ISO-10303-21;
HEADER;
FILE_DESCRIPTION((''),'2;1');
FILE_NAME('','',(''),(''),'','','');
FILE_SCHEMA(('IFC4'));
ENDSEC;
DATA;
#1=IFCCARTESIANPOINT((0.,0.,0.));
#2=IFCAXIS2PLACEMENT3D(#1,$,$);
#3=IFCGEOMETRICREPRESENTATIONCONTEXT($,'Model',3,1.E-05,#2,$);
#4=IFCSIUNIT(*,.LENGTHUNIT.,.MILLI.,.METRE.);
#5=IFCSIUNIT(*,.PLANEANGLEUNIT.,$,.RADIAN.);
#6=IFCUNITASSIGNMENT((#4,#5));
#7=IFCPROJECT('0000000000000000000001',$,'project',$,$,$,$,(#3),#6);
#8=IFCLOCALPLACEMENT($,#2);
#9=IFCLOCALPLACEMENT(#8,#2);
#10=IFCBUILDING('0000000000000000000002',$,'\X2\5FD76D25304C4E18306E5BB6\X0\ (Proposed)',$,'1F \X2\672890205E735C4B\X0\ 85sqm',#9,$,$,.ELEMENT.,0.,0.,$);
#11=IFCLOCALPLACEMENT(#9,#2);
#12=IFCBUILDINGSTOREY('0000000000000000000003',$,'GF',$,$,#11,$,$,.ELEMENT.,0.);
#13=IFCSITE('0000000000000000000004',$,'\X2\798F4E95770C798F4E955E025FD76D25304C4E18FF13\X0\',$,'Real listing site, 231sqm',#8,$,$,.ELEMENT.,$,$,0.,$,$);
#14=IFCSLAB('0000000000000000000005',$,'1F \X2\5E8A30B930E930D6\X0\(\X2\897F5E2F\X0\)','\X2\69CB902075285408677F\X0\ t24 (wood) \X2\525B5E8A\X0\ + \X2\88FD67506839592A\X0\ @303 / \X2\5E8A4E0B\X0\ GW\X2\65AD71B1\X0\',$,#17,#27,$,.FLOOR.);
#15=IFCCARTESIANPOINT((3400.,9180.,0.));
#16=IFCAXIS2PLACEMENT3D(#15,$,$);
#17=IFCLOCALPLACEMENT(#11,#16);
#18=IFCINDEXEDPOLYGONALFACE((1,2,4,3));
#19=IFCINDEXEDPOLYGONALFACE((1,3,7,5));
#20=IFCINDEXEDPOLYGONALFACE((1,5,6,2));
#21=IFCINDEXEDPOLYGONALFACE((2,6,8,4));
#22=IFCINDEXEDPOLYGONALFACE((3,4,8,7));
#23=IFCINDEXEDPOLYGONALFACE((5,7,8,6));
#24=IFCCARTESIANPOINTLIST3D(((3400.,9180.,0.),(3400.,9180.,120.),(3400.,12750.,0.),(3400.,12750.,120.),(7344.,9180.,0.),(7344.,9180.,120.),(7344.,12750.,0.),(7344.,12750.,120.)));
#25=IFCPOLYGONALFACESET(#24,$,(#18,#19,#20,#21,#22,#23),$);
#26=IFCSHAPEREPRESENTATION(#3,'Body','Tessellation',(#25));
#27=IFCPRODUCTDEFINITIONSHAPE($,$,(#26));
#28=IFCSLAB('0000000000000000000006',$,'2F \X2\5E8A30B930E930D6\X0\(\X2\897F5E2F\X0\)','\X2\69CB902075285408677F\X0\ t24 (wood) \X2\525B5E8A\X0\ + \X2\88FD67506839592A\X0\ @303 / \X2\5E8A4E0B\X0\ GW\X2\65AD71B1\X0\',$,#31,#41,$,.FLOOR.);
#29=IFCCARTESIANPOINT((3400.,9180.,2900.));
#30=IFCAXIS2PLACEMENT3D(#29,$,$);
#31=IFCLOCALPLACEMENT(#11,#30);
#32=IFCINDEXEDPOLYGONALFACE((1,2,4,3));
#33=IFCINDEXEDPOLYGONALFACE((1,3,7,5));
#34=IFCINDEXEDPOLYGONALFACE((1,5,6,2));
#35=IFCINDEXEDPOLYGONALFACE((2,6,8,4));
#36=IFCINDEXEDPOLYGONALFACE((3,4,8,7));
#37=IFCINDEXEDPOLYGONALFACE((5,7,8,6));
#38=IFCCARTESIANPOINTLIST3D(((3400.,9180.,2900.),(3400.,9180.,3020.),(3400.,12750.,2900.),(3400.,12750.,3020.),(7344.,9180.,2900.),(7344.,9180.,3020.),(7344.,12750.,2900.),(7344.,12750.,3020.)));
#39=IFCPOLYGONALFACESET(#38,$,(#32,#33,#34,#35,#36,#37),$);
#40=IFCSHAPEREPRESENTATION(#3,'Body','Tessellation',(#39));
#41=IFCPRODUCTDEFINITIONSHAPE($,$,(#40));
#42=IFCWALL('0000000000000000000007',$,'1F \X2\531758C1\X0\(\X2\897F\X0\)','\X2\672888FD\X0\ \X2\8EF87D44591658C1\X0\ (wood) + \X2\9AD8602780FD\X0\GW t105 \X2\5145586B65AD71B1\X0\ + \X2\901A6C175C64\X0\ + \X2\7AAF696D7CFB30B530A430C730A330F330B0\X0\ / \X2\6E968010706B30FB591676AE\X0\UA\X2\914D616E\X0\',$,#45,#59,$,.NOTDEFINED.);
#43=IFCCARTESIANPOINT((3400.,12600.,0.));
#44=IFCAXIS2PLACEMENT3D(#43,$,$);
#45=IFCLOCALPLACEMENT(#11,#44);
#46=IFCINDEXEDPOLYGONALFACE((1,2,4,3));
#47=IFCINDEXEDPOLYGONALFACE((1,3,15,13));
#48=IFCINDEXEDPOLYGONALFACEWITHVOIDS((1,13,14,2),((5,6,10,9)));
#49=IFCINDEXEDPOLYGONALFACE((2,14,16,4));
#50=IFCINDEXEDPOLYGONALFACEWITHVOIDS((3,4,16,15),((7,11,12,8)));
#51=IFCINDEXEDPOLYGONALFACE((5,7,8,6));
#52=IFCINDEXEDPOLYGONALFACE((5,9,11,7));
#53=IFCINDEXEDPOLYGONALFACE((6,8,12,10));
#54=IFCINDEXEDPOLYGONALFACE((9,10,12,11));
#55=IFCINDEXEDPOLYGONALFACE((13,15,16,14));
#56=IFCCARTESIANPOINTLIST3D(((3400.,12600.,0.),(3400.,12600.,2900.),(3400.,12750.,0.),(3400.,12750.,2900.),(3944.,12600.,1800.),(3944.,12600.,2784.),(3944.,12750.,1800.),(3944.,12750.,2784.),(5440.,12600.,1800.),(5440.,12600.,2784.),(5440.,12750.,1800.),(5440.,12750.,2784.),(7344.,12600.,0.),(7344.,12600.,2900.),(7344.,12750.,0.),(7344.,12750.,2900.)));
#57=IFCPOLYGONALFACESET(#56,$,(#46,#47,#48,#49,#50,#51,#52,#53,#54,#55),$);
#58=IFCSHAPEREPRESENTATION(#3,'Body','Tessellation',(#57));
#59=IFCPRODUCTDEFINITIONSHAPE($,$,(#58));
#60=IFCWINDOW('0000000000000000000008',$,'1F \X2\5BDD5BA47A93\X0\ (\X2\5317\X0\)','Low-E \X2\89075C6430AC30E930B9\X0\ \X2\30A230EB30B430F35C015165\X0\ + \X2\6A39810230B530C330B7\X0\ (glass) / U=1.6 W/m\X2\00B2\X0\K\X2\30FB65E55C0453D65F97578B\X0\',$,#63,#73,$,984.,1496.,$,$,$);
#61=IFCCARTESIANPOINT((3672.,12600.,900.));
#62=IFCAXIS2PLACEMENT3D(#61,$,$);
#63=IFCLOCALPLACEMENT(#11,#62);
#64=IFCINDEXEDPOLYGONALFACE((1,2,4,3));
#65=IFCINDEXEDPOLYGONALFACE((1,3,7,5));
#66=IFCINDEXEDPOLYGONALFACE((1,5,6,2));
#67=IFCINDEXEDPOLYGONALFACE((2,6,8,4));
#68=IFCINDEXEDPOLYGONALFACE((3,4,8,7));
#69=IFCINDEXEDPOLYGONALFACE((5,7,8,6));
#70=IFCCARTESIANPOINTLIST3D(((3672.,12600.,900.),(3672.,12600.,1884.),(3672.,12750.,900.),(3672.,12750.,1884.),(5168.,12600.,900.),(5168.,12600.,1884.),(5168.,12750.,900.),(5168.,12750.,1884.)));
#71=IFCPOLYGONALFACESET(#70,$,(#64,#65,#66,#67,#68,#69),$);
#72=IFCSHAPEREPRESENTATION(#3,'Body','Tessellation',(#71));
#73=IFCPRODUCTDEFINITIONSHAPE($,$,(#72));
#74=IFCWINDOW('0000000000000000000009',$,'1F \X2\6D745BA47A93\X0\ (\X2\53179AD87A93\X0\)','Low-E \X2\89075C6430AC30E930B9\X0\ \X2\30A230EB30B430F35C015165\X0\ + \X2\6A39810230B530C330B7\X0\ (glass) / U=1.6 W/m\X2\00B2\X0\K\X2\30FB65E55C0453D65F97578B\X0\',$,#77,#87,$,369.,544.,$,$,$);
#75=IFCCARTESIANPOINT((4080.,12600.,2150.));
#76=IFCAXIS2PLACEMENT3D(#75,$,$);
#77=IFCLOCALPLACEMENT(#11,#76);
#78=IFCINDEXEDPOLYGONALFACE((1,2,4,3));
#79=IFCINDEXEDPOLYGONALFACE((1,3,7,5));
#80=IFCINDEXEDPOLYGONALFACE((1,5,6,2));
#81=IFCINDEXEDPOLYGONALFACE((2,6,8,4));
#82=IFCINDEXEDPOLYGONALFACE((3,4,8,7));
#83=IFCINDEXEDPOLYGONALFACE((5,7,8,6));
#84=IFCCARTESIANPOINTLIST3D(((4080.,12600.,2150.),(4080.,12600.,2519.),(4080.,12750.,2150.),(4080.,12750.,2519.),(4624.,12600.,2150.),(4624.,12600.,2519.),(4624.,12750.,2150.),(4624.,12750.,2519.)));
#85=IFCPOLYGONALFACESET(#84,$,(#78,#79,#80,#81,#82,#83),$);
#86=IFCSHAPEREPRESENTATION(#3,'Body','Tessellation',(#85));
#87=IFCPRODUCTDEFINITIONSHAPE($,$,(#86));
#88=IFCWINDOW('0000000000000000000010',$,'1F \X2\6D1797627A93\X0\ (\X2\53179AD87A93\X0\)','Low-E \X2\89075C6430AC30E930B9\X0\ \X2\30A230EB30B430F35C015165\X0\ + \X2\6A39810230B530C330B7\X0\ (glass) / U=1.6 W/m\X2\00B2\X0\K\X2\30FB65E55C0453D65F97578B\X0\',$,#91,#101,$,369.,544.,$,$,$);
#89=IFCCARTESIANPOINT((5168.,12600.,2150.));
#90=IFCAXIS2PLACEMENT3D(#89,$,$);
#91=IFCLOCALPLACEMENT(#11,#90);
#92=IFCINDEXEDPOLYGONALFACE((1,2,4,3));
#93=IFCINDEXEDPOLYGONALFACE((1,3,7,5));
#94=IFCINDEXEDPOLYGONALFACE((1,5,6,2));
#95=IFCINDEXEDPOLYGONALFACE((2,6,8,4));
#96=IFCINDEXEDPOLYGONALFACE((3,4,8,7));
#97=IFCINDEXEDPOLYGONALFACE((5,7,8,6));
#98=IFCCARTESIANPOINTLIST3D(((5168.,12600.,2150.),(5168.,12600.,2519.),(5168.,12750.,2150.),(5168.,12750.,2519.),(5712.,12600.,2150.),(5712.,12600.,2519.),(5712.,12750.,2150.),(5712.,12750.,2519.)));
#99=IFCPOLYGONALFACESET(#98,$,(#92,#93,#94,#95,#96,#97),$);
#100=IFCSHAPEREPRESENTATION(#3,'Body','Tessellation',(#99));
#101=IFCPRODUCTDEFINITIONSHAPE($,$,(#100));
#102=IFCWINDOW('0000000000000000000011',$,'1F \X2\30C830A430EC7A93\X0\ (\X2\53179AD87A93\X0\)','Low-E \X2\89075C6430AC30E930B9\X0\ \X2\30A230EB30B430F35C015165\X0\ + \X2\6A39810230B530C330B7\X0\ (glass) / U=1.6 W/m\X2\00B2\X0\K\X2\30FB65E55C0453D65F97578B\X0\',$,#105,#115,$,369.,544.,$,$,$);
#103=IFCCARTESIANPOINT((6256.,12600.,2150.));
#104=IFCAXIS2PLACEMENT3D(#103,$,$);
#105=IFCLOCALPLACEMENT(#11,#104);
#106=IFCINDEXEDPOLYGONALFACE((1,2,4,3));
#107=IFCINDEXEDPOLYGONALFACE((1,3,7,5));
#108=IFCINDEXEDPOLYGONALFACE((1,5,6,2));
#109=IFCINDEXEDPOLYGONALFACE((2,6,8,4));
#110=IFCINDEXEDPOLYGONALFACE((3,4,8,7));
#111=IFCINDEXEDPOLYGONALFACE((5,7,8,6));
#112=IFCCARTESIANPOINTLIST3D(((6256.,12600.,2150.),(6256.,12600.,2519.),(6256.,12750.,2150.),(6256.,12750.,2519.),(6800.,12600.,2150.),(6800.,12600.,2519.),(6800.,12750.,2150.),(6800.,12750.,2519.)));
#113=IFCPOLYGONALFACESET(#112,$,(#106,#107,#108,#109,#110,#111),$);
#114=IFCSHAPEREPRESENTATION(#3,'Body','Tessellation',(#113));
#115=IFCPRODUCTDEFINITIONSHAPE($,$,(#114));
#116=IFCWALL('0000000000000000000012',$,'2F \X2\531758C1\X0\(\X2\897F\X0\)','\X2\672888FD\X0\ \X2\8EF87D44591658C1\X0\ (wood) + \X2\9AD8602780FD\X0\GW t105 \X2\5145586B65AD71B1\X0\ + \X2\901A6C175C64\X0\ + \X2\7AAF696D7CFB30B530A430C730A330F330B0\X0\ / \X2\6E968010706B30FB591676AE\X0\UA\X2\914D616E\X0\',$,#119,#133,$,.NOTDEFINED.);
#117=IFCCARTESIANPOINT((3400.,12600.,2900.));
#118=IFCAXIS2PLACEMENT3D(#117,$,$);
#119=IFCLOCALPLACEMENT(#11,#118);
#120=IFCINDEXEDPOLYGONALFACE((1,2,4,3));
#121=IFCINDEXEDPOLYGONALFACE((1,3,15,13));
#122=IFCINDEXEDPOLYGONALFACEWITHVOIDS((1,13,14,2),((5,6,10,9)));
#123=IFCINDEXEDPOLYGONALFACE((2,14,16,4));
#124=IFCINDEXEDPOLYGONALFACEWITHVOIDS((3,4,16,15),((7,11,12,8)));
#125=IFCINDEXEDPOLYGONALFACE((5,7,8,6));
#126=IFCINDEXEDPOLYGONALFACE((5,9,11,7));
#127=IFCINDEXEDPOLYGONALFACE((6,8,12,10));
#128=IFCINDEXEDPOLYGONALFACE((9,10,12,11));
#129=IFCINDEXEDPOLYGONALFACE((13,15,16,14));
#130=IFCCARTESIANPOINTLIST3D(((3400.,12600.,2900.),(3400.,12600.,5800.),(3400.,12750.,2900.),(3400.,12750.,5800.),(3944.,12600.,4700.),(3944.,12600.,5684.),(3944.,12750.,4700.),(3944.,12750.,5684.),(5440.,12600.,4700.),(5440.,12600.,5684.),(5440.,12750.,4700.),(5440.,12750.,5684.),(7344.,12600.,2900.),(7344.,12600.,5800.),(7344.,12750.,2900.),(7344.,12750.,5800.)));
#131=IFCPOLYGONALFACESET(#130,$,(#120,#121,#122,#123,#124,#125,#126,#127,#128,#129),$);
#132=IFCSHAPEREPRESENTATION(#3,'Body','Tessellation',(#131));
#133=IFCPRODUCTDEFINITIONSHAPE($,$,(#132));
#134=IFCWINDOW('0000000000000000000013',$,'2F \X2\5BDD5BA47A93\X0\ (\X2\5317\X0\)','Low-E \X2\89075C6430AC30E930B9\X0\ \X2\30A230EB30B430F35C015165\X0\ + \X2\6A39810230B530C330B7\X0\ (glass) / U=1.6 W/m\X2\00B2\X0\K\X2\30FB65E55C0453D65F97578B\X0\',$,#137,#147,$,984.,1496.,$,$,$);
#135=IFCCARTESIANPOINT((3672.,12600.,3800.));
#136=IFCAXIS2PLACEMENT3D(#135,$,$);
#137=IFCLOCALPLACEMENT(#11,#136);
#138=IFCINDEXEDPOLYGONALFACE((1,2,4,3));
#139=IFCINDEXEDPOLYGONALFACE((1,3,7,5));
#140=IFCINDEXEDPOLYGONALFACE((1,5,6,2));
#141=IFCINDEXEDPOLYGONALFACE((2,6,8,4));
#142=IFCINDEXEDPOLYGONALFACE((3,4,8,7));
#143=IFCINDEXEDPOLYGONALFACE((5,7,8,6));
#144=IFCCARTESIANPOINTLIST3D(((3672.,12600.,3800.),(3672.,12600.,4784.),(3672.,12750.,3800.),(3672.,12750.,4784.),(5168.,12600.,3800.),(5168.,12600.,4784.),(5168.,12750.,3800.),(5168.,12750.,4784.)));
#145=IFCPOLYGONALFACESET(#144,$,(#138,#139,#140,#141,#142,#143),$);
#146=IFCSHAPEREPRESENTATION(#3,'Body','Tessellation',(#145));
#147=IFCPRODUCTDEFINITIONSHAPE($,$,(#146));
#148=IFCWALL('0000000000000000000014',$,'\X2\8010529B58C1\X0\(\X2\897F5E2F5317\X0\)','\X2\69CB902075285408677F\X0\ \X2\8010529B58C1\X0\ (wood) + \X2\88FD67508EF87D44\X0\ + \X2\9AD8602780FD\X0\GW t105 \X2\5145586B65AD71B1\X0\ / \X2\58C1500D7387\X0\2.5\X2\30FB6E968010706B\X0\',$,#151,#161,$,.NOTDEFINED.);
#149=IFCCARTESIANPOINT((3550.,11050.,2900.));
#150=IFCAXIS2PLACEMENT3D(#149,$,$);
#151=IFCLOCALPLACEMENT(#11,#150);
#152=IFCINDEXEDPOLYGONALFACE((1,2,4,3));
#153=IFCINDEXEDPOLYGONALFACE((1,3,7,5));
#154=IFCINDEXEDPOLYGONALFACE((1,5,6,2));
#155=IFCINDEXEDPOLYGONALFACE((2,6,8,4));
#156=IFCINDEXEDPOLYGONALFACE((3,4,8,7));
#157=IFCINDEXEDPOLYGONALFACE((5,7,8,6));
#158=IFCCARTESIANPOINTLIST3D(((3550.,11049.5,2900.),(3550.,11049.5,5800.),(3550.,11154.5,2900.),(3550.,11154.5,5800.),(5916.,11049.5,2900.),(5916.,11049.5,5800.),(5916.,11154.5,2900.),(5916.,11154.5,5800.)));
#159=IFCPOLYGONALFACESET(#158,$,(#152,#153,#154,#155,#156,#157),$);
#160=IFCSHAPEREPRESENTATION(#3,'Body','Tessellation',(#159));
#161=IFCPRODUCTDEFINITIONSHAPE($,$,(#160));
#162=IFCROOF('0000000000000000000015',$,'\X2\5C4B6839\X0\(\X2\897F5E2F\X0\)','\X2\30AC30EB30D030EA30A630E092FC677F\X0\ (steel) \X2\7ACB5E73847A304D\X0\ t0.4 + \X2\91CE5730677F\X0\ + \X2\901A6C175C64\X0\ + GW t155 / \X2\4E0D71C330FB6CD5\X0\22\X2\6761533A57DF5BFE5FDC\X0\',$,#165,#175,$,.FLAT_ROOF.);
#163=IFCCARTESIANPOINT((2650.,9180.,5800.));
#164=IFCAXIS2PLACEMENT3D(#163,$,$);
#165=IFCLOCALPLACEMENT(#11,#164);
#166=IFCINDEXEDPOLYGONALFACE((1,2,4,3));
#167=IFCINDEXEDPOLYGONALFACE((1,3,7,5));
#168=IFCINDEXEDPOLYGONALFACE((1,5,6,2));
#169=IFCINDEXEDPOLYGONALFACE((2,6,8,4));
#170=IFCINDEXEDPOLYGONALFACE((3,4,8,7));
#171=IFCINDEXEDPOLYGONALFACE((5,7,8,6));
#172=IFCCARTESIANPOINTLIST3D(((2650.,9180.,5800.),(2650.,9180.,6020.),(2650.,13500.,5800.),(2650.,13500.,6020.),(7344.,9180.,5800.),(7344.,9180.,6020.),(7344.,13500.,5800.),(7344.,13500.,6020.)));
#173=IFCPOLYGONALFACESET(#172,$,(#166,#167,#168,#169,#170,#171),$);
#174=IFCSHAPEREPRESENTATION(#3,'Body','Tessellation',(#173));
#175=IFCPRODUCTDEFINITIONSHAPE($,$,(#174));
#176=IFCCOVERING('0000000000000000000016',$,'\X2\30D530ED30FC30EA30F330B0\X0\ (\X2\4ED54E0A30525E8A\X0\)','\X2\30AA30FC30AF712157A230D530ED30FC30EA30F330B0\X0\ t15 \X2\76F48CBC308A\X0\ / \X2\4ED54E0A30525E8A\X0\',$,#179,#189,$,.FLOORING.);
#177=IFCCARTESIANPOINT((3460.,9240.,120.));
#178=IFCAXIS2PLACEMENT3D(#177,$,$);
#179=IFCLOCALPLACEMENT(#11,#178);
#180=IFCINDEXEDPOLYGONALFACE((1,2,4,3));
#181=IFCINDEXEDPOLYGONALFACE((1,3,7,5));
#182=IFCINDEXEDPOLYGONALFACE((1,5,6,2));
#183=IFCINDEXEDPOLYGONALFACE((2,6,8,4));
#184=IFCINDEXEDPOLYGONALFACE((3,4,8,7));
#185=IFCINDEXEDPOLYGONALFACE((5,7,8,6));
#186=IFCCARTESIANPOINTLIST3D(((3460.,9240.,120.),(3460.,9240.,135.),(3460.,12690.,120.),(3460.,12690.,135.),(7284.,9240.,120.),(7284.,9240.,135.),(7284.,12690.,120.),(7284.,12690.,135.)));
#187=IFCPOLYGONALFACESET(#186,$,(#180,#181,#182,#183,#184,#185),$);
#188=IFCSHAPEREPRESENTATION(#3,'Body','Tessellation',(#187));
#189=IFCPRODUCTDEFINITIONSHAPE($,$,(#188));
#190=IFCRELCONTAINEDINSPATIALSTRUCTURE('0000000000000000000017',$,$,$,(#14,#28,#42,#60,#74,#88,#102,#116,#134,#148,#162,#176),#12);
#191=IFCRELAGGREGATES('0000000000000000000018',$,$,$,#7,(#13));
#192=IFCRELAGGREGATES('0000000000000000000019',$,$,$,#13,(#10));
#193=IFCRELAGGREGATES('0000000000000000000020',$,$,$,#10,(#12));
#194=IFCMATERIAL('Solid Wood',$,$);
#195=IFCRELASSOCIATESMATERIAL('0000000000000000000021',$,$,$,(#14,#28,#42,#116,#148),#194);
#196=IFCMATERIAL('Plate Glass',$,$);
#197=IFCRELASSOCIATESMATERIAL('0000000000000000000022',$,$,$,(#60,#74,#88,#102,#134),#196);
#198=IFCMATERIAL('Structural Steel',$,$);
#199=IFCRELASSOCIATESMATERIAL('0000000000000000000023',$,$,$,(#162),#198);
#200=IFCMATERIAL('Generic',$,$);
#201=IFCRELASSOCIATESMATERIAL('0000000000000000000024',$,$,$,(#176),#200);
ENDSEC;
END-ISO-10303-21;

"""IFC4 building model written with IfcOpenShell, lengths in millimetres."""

from ifc_helpers import new_model, si_unit, frame, frame_2d, origin, place, context, project, spatial, rectangle, extrude, material, element, fill, save


model = new_model("IFC4")

# Units and contexts
model_context = context("Model", 3, precision=1e-05, world=origin())
ifc_project = project(units=[si_unit("LENGTHUNIT", "METRE", prefix="MILLI"), si_unit("PLANEANGLEUNIT", "RADIAN")], contexts=[model_context])

# Site, building, storey
site_placement = place(None, origin())
site = spatial("IfcSite", under=ifc_project, at=site_placement, Name="福井県福井市志津が丘３", ObjectType="Real listing site, 231sqm", CompositionType="ELEMENT", RefElevation=0.0)
building_placement = place(site_placement, origin())
building = spatial("IfcBuilding", under=site, at=building_placement, Name="志津が丘の家 (Proposed)", ObjectType="1F 木造平屋 85sqm", CompositionType="ELEMENT", ElevationOfRefHeight=0.0, ElevationOfTerrain=0.0)
storey_placement = place(building_placement, origin())
storey = spatial("IfcBuildingStorey", under=building, at=storey_placement, Name="GF", CompositionType="ELEMENT", Elevation=0.0)

# Slabs
ifc_material_1 = material(Name="Solid Wood")
slab_1_placement = place(storey_placement, frame((3400.0, 9180.0, 0.0)))
element("IfcSlab", 1, at=slab_1_placement, inside=storey, material=ifc_material_1, Name="1F 床スラブ(西帯)", Description="構造用合板 t24 (wood) 剛床 + 製材根太 @303 / 床下 GW断熱", PredefinedType="FLOOR", context=model_context, shape_type="SweptSolid", body=[
    extrude(rectangle(XDim=3944.0, YDim=3570.0, at=frame_2d((1972.0, 1785.0))), frame((3400.0, 9180.0, 0.0)), (0.0, 0.0, 1.0), 120.0),
])
slab_2_placement = place(storey_placement, frame((3400.0, 9180.0, 2900.0)))
element("IfcSlab", 2, at=slab_2_placement, inside=storey, material=ifc_material_1, Name="2F 床スラブ(西帯)", Description="構造用合板 t24 (wood) 剛床 + 製材根太 @303 / 床下 GW断熱", PredefinedType="FLOOR", context=model_context, shape_type="SweptSolid", body=[
    extrude(rectangle(XDim=3944.0, YDim=3570.0, at=frame_2d((1972.0, 1785.0))), frame((3400.0, 9180.0, 2900.0)), (0.0, 0.0, 1.0), 120.0),
])

# Wall, openings, windows
wall_1_placement = place(storey_placement, frame((3400.0, 12600.0, 0.0)))
wall_1 = element("IfcWall", 3, at=wall_1_placement, inside=storey, material=ifc_material_1, Name="1F 北壁(西)", Description="木製 軸組外壁 (wood) + 高性能GW t105 充填断熱 + 通気層 + 窯業系サイディング / 準耐火・外皮UA配慮", PredefinedType="NOTDEFINED", context=model_context, shape_type="SweptSolid", body=[
    extrude(rectangle(XDim=3944.0, YDim=150.0, at=frame_2d((1972.0, 75.0))), frame((3400.0, 12600.0, 0.0)), (0.0, 0.0, 1.0), 2900.0),
])
opening_1_placement = place(storey_placement, frame((3672.0, 12600.0, 900.0)))
opening_1 = element("IfcOpeningElement", 4, at=opening_1_placement, cuts=wall_1, PredefinedType="NOTDEFINED", context=model_context, shape_type="SweptSolid", body=[
    extrude(rectangle(XDim=1496.0, YDim=150.0, at=frame_2d((748.0, 75.0))), frame((3672.0, 12600.0, 900.0)), (0.0, 0.0, 1.0), 984.0),
])
opening_2_placement = place(storey_placement, frame((4080.0, 12600.0, 2150.0)))
opening_2 = element("IfcOpeningElement", 5, at=opening_2_placement, cuts=wall_1, PredefinedType="NOTDEFINED", context=model_context, shape_type="SweptSolid", body=[
    extrude(rectangle(XDim=544.0, YDim=150.0, at=frame_2d((272.0, 75.0))), frame((4080.0, 12600.0, 2150.0)), (0.0, 0.0, 1.0), 369.0),
])
opening_3_placement = place(storey_placement, frame((5168.0, 12600.0, 2150.0)))
opening_3 = element("IfcOpeningElement", 6, at=opening_3_placement, cuts=wall_1, PredefinedType="NOTDEFINED", context=model_context, shape_type="SweptSolid", body=[
    extrude(rectangle(XDim=544.0, YDim=150.0, at=frame_2d((272.0, 75.0))), frame((5168.0, 12600.0, 2150.0)), (0.0, 0.0, 1.0), 369.0),
])
opening_4_placement = place(storey_placement, frame((6256.0, 12600.0, 2150.0)))
opening_4 = element("IfcOpeningElement", 7, at=opening_4_placement, cuts=wall_1, PredefinedType="NOTDEFINED", context=model_context, shape_type="SweptSolid", body=[
    extrude(rectangle(XDim=544.0, YDim=150.0, at=frame_2d((272.0, 75.0))), frame((6256.0, 12600.0, 2150.0)), (0.0, 0.0, 1.0), 369.0),
])
ifc_material_2 = material(Name="Plate Glass")
window_1_placement = place(storey_placement, frame((3672.0, 12600.0, 900.0)))
window_1 = element("IfcWindow", 8, at=window_1_placement, inside=storey, material=ifc_material_2, Name="1F 寝室窓 (北)", Description="Low-E 複層ガラス アルゴン封入 + 樹脂サッシ (glass) / U=1.6 W/m²K・日射取得型", OverallHeight=984.0, OverallWidth=1496.0, context=model_context, shape_type="SweptSolid", body=[
    extrude(rectangle(XDim=1496.0, YDim=150.0, at=frame_2d((748.0, 75.0))), frame((3672.0, 12600.0, 900.0)), (0.0, 0.0, 1.0), 984.0),
])
fill(opening_1, window_1)
window_2_placement = place(storey_placement, frame((4080.0, 12600.0, 2150.0)))
window_2 = element("IfcWindow", 9, at=window_2_placement, inside=storey, material=ifc_material_2, Name="1F 浴室窓 (北高窓)", Description="Low-E 複層ガラス アルゴン封入 + 樹脂サッシ (glass) / U=1.6 W/m²K・日射取得型", OverallHeight=369.0, OverallWidth=544.0, context=model_context, shape_type="SweptSolid", body=[
    extrude(rectangle(XDim=544.0, YDim=150.0, at=frame_2d((272.0, 75.0))), frame((4080.0, 12600.0, 2150.0)), (0.0, 0.0, 1.0), 369.0),
])
fill(opening_2, window_2)
window_3_placement = place(storey_placement, frame((5168.0, 12600.0, 2150.0)))
window_3 = element("IfcWindow", 10, at=window_3_placement, inside=storey, material=ifc_material_2, Name="1F 洗面窓 (北高窓)", Description="Low-E 複層ガラス アルゴン封入 + 樹脂サッシ (glass) / U=1.6 W/m²K・日射取得型", OverallHeight=369.0, OverallWidth=544.0, context=model_context, shape_type="SweptSolid", body=[
    extrude(rectangle(XDim=544.0, YDim=150.0, at=frame_2d((272.0, 75.0))), frame((5168.0, 12600.0, 2150.0)), (0.0, 0.0, 1.0), 369.0),
])
fill(opening_3, window_3)
window_4_placement = place(storey_placement, frame((6256.0, 12600.0, 2150.0)))
window_4 = element("IfcWindow", 11, at=window_4_placement, inside=storey, material=ifc_material_2, Name="1F トイレ窓 (北高窓)", Description="Low-E 複層ガラス アルゴン封入 + 樹脂サッシ (glass) / U=1.6 W/m²K・日射取得型", OverallHeight=369.0, OverallWidth=544.0, context=model_context, shape_type="SweptSolid", body=[
    extrude(rectangle(XDim=544.0, YDim=150.0, at=frame_2d((272.0, 75.0))), frame((6256.0, 12600.0, 2150.0)), (0.0, 0.0, 1.0), 369.0),
])
fill(opening_4, window_4)

# Wall, opening, window
wall_2_placement = place(storey_placement, frame((3400.0, 12600.0, 2900.0)))
wall_2 = element("IfcWall", 12, at=wall_2_placement, inside=storey, material=ifc_material_1, Name="2F 北壁(西)", Description="木製 軸組外壁 (wood) + 高性能GW t105 充填断熱 + 通気層 + 窯業系サイディング / 準耐火・外皮UA配慮", PredefinedType="NOTDEFINED", context=model_context, shape_type="SweptSolid", body=[
    extrude(rectangle(XDim=3944.0, YDim=150.0, at=frame_2d((1972.0, 75.0))), frame((3400.0, 12600.0, 2900.0)), (0.0, 0.0, 1.0), 2900.0),
])
opening_5_placement = place(storey_placement, frame((3672.0, 12600.0, 3800.0)))
opening_5 = element("IfcOpeningElement", 13, at=opening_5_placement, cuts=wall_2, PredefinedType="NOTDEFINED", context=model_context, shape_type="SweptSolid", body=[
    extrude(rectangle(XDim=1496.0, YDim=150.0, at=frame_2d((748.0, 75.0))), frame((3672.0, 12600.0, 3800.0)), (0.0, 0.0, 1.0), 984.0),
])
window_5_placement = place(storey_placement, frame((3672.0, 12600.0, 3800.0)))
window_5 = element("IfcWindow", 14, at=window_5_placement, inside=storey, material=ifc_material_2, Name="2F 寝室窓 (北)", Description="Low-E 複層ガラス アルゴン封入 + 樹脂サッシ (glass) / U=1.6 W/m²K・日射取得型", OverallHeight=984.0, OverallWidth=1496.0, context=model_context, shape_type="SweptSolid", body=[
    extrude(rectangle(XDim=1496.0, YDim=150.0, at=frame_2d((748.0, 75.0))), frame((3672.0, 12600.0, 3800.0)), (0.0, 0.0, 1.0), 984.0),
])
fill(opening_5, window_5)

# Wall
wall_3_placement = place(storey_placement, frame((3550.0, 11050.0, 2900.0)))
element("IfcWall", 15, at=wall_3_placement, inside=storey, material=ifc_material_1, Name="耐力壁(西帯北)", Description="構造用合板 耐力壁 (wood) + 製材軸組 + 高性能GW t105 充填断熱 / 壁倍率2.5・準耐火", PredefinedType="NOTDEFINED", context=model_context, shape_type="SweptSolid", body=[
    extrude(rectangle(XDim=2366.0, YDim=105.0, at=frame_2d((1183.0, 52.0))), frame((3550.0, 11050.0, 2900.0)), (0.0, 0.0, 1.0), 2900.0),
])

# Roof
ifc_material_3 = material(Name="Structural Steel")
for number, where, name in (
    (16, (2650.0, 9180.0, 5800.0), "屋根(西帯)"),
):
    element("IfcRoof", number, at=place(storey_placement, frame(where)), inside=storey, material=ifc_material_3, Name=name, Description="ガルバリウム鋼板 (steel) 立平葺き t0.4 + 野地板 + 通気層 + GW t155 / 不燃・法22条区域対応", PredefinedType="FLAT_ROOF", context=model_context, shape_type="SweptSolid", body=[
        extrude(rectangle(XDim=4694.0, YDim=4320.0, at=frame_2d((2347.0, 2160.0))), frame((2650.0, 9180.0, 5800.0)), (0.0, 0.0, 1.0), 220.0),
    ])

# Covering
ifc_material_4 = material(Name="Generic")
covering_1_placement = place(storey_placement, frame((3460.0, 9240.0, 120.0)))
element("IfcCovering", 17, at=covering_1_placement, inside=storey, material=ifc_material_4, Name="フローリング (仕上げ床)", Description="オーク無垢フローリング t15 直貼り / 仕上げ床", PredefinedType="FLOORING", context=model_context, shape_type="SweptSolid", body=[
    extrude(rectangle(XDim=3824.0, YDim=3450.0, at=frame_2d((1912.0, 1725.0))), frame((3460.0, 9240.0, 120.0)), (0.0, 0.0, 1.0), 15.0),
])

save(model, "model.ifc")
